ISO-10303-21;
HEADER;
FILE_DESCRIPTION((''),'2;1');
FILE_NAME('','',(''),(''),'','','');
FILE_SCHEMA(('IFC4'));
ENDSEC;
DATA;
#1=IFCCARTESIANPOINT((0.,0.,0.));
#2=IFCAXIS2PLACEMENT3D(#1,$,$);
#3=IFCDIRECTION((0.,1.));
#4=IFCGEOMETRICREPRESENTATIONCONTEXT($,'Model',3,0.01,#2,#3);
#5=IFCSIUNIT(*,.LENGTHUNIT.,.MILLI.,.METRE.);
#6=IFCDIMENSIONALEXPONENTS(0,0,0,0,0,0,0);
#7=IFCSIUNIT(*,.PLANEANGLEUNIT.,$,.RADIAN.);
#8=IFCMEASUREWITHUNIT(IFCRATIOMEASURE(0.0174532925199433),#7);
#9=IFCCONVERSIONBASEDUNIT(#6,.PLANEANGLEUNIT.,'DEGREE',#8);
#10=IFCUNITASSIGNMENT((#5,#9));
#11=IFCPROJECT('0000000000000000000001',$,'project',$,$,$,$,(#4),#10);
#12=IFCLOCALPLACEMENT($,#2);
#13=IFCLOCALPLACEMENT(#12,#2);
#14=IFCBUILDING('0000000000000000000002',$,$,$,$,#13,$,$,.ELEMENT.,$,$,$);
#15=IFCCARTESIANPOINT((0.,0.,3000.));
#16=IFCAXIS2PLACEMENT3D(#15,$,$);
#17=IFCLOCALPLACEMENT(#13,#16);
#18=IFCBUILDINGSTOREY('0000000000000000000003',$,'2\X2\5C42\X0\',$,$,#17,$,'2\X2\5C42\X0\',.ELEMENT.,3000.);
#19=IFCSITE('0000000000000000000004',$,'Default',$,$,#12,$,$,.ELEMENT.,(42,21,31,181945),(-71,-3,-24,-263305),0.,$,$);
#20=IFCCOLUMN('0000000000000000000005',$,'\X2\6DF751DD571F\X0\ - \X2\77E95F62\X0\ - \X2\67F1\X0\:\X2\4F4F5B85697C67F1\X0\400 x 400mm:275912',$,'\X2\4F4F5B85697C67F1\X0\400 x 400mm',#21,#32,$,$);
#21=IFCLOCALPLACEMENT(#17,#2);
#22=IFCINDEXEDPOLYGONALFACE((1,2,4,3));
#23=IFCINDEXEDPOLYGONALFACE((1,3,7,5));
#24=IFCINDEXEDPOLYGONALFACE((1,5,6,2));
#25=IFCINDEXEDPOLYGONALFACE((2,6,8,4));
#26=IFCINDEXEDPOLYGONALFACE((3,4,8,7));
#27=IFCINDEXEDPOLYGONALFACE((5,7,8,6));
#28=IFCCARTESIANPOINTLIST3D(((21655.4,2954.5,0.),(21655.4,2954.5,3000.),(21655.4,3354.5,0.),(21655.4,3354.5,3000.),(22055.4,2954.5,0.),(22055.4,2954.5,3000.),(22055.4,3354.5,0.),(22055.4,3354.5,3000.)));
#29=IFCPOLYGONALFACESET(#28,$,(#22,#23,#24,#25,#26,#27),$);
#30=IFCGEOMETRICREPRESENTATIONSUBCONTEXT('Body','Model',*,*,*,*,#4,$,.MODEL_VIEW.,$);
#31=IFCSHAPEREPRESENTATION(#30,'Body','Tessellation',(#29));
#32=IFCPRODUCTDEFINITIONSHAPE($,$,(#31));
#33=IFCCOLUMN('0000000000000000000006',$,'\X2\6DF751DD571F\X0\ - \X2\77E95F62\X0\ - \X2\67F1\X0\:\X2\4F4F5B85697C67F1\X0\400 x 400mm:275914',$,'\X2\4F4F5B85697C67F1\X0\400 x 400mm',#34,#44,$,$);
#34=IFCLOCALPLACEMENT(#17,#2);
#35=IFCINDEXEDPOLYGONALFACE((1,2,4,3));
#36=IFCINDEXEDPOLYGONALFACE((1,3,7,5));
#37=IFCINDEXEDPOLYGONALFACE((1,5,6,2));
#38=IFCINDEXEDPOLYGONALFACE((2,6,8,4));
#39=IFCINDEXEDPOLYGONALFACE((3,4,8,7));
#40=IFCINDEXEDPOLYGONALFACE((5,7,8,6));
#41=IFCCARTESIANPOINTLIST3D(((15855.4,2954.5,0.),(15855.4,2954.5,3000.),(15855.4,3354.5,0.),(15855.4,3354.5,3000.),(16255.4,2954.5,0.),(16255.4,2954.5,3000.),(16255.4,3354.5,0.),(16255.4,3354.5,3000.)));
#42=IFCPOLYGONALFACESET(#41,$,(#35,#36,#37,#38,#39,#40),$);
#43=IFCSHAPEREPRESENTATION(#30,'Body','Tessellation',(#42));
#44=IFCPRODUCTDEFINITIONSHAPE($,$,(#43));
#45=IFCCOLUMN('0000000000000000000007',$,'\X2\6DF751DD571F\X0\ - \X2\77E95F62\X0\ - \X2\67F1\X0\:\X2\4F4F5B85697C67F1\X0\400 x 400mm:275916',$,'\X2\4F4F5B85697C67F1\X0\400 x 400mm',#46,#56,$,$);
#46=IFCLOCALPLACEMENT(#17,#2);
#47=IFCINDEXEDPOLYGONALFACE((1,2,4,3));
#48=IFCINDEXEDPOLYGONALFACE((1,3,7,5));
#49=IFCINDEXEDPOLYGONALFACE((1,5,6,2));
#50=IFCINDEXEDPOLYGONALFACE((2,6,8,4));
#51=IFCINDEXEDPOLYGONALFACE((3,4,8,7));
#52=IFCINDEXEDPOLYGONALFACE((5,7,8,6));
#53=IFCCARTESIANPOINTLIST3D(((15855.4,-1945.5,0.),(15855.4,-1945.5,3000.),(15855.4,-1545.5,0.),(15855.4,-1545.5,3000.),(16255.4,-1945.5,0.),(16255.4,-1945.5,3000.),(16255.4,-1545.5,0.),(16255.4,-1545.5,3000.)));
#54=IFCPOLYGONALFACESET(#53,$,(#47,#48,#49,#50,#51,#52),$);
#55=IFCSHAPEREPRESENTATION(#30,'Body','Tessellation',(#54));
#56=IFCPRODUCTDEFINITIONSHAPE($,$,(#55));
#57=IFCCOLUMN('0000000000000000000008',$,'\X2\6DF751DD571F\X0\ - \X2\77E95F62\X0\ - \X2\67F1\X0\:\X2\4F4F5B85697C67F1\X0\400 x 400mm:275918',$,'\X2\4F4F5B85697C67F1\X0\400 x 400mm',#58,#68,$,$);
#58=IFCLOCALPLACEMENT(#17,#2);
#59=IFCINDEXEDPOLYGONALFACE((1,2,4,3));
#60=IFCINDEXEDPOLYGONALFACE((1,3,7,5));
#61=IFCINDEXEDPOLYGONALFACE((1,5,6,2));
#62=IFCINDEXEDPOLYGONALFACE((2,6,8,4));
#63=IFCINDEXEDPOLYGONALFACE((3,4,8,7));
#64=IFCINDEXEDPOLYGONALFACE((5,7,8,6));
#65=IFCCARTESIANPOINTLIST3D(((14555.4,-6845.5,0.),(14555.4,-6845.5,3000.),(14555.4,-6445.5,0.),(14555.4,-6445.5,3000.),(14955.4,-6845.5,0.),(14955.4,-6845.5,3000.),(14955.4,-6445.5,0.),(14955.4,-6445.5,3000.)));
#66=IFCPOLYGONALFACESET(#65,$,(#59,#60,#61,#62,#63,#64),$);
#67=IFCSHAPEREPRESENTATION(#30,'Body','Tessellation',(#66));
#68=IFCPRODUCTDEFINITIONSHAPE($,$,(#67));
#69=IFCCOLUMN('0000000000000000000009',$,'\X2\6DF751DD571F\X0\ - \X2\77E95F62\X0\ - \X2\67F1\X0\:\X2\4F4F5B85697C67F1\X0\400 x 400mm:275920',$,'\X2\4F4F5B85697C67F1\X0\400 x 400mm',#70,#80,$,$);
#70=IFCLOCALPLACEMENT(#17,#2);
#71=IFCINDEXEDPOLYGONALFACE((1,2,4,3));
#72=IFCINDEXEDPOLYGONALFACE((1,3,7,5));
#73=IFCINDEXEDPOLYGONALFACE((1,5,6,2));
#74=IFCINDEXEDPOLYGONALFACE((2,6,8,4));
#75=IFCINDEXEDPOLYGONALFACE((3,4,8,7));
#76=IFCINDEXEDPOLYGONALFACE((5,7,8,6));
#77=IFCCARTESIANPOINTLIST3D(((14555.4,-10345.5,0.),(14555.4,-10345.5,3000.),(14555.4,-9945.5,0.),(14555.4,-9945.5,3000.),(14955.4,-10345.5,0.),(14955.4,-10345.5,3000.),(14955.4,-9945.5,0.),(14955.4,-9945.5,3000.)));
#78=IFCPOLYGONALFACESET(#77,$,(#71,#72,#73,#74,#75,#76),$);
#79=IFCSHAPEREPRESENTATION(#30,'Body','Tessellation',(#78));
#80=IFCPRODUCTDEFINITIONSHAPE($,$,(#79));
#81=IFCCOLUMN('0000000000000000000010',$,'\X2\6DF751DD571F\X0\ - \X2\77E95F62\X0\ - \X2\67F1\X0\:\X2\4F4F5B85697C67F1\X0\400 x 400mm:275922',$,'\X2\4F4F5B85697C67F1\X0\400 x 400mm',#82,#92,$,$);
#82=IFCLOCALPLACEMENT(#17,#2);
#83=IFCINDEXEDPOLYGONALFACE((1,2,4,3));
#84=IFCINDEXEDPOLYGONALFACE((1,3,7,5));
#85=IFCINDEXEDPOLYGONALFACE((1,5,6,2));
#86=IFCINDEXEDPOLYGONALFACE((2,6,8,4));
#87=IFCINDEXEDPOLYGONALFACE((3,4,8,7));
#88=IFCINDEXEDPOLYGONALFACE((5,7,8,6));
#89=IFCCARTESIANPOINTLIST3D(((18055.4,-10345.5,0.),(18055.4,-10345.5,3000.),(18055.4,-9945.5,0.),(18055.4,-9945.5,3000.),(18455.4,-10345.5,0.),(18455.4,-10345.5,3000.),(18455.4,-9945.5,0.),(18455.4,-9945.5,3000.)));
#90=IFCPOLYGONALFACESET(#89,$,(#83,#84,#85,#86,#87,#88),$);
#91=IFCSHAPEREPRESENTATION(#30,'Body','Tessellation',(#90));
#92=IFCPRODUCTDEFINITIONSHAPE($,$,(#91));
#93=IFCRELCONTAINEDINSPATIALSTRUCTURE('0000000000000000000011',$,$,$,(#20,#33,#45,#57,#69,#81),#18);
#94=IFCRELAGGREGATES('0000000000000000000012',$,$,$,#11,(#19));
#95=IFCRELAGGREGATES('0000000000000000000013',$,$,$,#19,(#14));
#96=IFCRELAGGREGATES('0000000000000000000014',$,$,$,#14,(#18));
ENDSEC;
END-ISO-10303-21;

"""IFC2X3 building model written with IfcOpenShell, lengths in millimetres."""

from ifc_helpers import new_model, entity, si_unit, converted_unit, direction, frame, frame_2d, origin, origin_2d_with_axis, place, context, subcontext, project, spatial, rectangle, extrude, source, transform, mapped, element, save


model = new_model("IFC2X3")

# Units and contexts
model_context = context("Model", 3, precision=0.01, world=origin(), true_north=direction((0.0, 1.0)))
body_context = subcontext(model_context, "Body", "Model", "MODEL_VIEW")
ifc_project = project(units=[si_unit("LENGTHUNIT", "METRE", prefix="MILLI"), converted_unit("PLANEANGLEUNIT", "DEGREE", entity("IfcRatioMeasure", 0.0174532925199433), si_unit("PLANEANGLEUNIT", "RADIAN"), dimensions=[0, 0, 0, 0, 0, 0, 0])], contexts=[model_context])

# Site, building, storey
site_placement = place(None, origin())
site = spatial("IfcSite", under=ifc_project, at=site_placement, Name="Default", CompositionType="ELEMENT", RefLatitude=(42, 21, 31, 181945), RefLongitude=(-71, -3, -24, -263305), RefElevation=0.0)
building_placement = place(site_placement, origin())
building = spatial("IfcBuilding", under=site, at=building_placement, CompositionType="ELEMENT")
storey_placement = place(building_placement, frame((0.0, 0.0, 3000.0)))
storey = spatial("IfcBuildingStorey", under=building, at=storey_placement, Name="2层", LongName="2层", CompositionType="ELEMENT", Elevation=3000.0)

# Columns
shared_shape_1 = source(origin(), body_context, "Body", "SweptSolid", [
    extrude(rectangle(XDim=400.0, YDim=400.0, at=frame_2d((0.0, 0.0), x_axis=(1.0, 0.0))), frame((21855.4, 3154.5, 3000.0), z_axis=(0.0, 0.0, 1.0), x_axis=(0.0, -1.0, 0.0)), (0.0, 0.0, 1.0), 3000.0),
])
column_1_placement = place(storey_placement, frame((0.0, 0.0, -3000.0)))
element("IfcColumn", 1, at=column_1_placement, inside=storey, Name="混凝土 - 矩形 - 柱:住宅楼柱400 x 400mm:275912", ObjectType="住宅楼柱400 x 400mm", context=body_context, shape_type="MappedRepresentation", body=[
    mapped(shared_shape_1, transform((0.0, 0.0, 0.0), scale=1.0)),
])
shared_shape_2 = source(origin(), body_context, "Body", "SweptSolid", [
    extrude(rectangle(XDim=400.0, YDim=400.0, at=origin_2d_with_axis()), frame((16055.4, 3154.5, 3000.0), z_axis=(0.0, 0.0, 1.0), x_axis=(0.0, -1.0, 0.0)), (0.0, 0.0, 1.0), 3000.0),
])
column_2_placement = place(storey_placement, frame((0.0, 0.0, -3000.0)))
element("IfcColumn", 2, at=column_2_placement, inside=storey, Name="混凝土 - 矩形 - 柱:住宅楼柱400 x 400mm:275914", ObjectType="住宅楼柱400 x 400mm", context=body_context, shape_type="MappedRepresentation", body=[
    mapped(shared_shape_2, transform((0.0, 0.0, 0.0), scale=1.0)),
])
shared_shape_3 = source(origin(), body_context, "Body", "SweptSolid", [
    extrude(rectangle(XDim=400.0, YDim=400.0, at=origin_2d_with_axis()), frame((16055.4, -1745.5, 3000.0), z_axis=(0.0, 0.0, 1.0), x_axis=(0.0, -1.0, 0.0)), (0.0, 0.0, 1.0), 3000.0),
])
column_3_placement = place(storey_placement, frame((0.0, 0.0, -3000.0)))
element("IfcColumn", 3, at=column_3_placement, inside=storey, Name="混凝土 - 矩形 - 柱:住宅楼柱400 x 400mm:275916", ObjectType="住宅楼柱400 x 400mm", context=body_context, shape_type="MappedRepresentation", body=[
    mapped(shared_shape_3, transform((0.0, 0.0, 0.0), scale=1.0)),
])
shared_shape_4 = source(origin(), body_context, "Body", "SweptSolid", [
    extrude(rectangle(XDim=400.0, YDim=400.0, at=frame_2d((0.0, 0.0), x_axis=(1.0, 0.0))), frame((14755.4, -6645.5, 3000.0), z_axis=(0.0, 0.0, 1.0), x_axis=(0.0, -1.0, 0.0)), (0.0, 0.0, 1.0), 3000.0),
])
column_4_placement = place(storey_placement, frame((0.0, 0.0, -3000.0)))
element("IfcColumn", 4, at=column_4_placement, inside=storey, Name="混凝土 - 矩形 - 柱:住宅楼柱400 x 400mm:275918", ObjectType="住宅楼柱400 x 400mm", context=body_context, shape_type="MappedRepresentation", body=[
    mapped(shared_shape_4, transform((0.0, 0.0, 0.0), scale=1.0)),
])
shared_shape_5 = source(origin(), body_context, "Body", "SweptSolid", [
    extrude(rectangle(XDim=400.0, YDim=400.0, at=origin_2d_with_axis()), frame((14755.4, -10145.5, 3000.0), z_axis=(0.0, 0.0, 1.0), x_axis=(0.0, -1.0, 0.0)), (0.0, 0.0, 1.0), 3000.0),
])
column_5_placement = place(storey_placement, frame((0.0, 0.0, -3000.0)))
element("IfcColumn", 5, at=column_5_placement, inside=storey, Name="混凝土 - 矩形 - 柱:住宅楼柱400 x 400mm:275920", ObjectType="住宅楼柱400 x 400mm", context=body_context, shape_type="MappedRepresentation", body=[
    mapped(shared_shape_5, transform((0.0, 0.0, 0.0), scale=1.0)),
])
shared_shape_6 = source(origin(), body_context, "Body", "SweptSolid", [
    extrude(rectangle(XDim=400.0, YDim=400.0, at=origin_2d_with_axis()), frame((18255.4, -10145.5, 3000.0), z_axis=(0.0, 0.0, 1.0), x_axis=(0.0, -1.0, 0.0)), (0.0, 0.0, 1.0), 3000.0),
])
column_6_placement = place(storey_placement, frame((0.0, 0.0, -3000.0)))
element("IfcColumn", 6, at=column_6_placement, inside=storey, Name="混凝土 - 矩形 - 柱:住宅楼柱400 x 400mm:275922", ObjectType="住宅楼柱400 x 400mm", context=body_context, shape_type="MappedRepresentation", body=[
    mapped(shared_shape_6, transform((0.0, 0.0, 0.0), scale=1.0)),
])

save(model, "model.ifc")
